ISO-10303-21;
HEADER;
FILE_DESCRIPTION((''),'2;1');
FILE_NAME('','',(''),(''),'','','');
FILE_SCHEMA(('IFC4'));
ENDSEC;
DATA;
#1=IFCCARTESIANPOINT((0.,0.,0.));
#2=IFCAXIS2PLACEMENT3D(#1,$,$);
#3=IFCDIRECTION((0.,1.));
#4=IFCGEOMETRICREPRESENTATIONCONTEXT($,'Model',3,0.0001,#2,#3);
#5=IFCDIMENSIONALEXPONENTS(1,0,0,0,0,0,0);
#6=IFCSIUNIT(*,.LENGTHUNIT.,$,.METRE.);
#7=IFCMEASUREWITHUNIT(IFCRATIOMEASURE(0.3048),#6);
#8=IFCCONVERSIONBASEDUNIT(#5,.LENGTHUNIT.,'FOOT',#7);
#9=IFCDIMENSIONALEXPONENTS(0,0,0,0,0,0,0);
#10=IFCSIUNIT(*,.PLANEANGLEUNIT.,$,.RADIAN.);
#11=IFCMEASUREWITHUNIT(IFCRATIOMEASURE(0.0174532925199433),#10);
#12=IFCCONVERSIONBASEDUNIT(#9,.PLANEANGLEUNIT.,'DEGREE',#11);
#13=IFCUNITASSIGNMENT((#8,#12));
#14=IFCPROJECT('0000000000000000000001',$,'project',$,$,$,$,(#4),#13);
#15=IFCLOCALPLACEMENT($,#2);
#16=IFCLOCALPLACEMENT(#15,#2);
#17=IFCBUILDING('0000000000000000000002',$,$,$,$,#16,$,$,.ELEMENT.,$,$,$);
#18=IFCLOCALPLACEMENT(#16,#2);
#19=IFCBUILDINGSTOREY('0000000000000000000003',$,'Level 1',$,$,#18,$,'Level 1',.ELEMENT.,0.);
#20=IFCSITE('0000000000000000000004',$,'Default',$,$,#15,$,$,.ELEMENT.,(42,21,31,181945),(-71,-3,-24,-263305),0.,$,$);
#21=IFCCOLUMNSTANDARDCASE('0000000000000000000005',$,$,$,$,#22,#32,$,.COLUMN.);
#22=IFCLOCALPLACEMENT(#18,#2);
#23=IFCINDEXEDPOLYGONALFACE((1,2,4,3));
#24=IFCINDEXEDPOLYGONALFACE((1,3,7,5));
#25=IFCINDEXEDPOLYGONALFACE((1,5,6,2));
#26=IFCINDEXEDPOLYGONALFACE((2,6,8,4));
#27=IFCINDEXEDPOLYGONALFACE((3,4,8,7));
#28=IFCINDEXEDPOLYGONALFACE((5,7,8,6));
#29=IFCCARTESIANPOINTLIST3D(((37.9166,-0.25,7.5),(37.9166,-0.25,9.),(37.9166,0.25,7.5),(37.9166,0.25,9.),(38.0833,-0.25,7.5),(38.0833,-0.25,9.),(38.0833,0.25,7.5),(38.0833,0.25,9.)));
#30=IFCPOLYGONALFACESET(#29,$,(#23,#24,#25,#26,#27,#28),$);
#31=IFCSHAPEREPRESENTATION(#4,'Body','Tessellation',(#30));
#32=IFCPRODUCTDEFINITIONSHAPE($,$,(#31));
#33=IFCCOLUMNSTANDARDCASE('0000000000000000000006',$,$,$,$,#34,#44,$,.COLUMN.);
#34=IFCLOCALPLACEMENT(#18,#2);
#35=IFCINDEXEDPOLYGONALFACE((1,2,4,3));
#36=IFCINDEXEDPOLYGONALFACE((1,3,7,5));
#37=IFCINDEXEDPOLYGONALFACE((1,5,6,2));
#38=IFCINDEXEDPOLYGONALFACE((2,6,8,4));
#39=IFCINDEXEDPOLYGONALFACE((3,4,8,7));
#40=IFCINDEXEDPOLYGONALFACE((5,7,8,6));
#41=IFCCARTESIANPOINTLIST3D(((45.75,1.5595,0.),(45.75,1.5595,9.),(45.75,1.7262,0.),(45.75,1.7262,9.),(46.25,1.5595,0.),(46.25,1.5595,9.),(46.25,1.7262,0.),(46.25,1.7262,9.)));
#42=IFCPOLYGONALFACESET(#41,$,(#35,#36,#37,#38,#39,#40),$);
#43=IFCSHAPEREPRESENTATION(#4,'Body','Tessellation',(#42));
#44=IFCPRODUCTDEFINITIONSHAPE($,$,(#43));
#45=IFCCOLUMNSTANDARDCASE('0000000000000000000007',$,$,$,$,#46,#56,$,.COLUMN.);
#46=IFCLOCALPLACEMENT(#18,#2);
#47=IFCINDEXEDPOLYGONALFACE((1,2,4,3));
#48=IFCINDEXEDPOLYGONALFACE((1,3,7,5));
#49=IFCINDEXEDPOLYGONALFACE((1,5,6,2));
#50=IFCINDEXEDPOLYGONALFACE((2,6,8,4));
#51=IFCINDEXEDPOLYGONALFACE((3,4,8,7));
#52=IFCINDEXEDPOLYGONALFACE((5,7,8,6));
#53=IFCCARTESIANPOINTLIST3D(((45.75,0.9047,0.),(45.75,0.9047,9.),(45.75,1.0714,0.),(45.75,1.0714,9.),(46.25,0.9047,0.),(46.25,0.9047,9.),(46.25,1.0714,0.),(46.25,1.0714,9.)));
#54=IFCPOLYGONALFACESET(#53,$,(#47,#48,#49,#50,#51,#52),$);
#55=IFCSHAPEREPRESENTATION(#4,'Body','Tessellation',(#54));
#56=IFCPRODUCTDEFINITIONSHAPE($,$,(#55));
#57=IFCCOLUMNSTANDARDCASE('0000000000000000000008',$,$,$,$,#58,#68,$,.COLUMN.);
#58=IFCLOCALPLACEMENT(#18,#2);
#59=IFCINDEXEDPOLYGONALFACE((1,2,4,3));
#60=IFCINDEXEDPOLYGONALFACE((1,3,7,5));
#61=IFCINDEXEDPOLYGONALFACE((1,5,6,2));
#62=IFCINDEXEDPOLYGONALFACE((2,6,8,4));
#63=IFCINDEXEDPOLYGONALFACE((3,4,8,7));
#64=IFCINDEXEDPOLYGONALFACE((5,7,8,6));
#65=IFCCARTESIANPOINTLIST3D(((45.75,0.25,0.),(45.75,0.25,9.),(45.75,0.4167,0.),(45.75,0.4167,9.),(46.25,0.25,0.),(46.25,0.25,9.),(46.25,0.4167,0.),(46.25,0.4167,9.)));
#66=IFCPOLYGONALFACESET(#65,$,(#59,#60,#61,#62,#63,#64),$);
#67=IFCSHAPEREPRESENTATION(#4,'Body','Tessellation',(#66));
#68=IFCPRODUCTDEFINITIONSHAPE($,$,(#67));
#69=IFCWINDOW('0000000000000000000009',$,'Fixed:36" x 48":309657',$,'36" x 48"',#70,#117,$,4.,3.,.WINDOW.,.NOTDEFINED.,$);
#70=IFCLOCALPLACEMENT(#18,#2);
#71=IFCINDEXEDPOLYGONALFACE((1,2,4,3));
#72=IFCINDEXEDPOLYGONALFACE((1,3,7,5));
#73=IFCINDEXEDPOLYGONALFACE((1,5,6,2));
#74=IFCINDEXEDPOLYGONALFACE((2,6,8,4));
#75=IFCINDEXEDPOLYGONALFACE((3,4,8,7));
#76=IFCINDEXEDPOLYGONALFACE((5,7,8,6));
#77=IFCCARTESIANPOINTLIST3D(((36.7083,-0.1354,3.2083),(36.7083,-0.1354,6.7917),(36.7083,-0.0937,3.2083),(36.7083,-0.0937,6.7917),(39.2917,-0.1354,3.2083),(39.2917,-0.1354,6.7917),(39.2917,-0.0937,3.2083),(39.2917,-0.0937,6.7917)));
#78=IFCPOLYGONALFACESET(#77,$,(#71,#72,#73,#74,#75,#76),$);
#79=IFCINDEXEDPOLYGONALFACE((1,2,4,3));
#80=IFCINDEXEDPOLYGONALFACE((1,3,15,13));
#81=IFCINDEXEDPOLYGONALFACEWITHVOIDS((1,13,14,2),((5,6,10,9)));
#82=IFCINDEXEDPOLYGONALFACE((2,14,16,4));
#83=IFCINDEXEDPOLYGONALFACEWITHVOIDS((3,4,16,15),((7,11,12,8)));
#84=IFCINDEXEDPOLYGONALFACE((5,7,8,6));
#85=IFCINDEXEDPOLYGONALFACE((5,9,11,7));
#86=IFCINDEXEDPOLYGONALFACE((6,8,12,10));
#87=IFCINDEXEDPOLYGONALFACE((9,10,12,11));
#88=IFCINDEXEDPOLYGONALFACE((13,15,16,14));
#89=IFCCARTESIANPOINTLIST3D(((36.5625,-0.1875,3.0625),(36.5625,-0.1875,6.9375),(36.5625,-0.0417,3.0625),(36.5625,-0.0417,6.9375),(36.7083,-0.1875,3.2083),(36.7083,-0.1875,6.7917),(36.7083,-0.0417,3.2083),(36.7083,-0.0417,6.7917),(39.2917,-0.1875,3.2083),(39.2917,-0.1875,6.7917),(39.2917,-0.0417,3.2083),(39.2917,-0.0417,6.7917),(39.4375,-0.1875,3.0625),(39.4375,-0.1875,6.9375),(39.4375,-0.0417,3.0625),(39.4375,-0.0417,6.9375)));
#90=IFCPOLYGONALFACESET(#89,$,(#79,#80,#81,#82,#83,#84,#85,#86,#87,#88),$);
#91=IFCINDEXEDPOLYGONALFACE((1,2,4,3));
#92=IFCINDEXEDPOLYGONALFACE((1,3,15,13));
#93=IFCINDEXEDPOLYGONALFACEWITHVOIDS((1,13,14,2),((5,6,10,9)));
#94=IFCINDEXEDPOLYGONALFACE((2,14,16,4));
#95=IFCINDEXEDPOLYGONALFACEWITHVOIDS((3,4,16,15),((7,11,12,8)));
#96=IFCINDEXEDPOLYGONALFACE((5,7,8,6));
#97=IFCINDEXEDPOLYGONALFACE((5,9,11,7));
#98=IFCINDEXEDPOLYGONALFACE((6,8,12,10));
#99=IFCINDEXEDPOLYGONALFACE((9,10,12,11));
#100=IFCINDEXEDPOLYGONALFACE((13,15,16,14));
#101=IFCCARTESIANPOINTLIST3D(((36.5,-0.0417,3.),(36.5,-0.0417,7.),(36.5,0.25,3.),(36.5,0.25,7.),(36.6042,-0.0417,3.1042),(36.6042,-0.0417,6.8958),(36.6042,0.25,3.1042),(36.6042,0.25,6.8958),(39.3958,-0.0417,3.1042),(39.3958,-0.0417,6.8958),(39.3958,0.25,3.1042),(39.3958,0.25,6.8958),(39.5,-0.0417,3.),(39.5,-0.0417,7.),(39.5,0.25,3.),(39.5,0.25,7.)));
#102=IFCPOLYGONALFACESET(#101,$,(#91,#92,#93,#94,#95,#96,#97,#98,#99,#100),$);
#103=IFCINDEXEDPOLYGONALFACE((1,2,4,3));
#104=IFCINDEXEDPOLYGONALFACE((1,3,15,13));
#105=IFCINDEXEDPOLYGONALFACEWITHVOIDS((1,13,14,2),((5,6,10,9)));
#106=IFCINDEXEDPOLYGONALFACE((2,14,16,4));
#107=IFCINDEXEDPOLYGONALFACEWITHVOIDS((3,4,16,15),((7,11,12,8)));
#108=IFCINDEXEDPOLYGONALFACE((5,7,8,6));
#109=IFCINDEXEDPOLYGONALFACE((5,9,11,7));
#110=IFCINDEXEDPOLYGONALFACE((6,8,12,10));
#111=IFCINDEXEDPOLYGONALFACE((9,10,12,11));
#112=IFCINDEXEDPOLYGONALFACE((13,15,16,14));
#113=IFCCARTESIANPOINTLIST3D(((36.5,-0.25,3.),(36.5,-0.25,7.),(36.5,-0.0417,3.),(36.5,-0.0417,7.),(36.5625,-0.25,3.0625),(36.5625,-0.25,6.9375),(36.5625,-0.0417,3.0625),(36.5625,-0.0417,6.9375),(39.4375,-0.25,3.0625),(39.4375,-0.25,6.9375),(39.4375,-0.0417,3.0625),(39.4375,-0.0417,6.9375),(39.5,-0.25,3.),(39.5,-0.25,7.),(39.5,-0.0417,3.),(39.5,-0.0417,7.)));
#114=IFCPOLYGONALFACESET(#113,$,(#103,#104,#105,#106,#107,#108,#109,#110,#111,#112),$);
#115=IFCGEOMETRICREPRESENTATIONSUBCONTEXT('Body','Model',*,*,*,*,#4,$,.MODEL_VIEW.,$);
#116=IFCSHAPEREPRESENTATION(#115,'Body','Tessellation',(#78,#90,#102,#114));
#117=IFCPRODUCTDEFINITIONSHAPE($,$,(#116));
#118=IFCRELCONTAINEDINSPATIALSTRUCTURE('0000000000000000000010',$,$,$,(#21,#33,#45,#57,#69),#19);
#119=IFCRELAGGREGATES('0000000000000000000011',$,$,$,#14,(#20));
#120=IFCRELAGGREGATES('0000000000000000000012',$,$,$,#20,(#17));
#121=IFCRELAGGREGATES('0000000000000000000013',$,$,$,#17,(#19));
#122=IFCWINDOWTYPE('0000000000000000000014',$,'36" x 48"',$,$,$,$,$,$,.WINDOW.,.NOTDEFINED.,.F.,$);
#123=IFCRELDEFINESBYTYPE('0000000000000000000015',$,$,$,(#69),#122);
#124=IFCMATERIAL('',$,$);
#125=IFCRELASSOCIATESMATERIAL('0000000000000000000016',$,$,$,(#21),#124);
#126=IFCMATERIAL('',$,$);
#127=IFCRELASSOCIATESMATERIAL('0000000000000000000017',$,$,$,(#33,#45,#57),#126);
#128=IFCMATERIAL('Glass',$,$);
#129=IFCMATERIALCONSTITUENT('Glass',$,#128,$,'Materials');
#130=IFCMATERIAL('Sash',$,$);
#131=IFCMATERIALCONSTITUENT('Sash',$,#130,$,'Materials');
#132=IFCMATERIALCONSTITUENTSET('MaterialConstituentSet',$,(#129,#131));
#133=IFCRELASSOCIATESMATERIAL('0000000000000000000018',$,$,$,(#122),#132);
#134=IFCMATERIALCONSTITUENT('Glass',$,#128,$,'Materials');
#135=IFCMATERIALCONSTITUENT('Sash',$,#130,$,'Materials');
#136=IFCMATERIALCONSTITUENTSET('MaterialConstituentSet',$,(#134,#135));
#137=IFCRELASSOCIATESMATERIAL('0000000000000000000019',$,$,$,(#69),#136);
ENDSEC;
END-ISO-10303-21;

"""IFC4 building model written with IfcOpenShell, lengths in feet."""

from ifc_helpers import new_model, entity, si_unit, converted_unit, direction, frame, frame_2d, origin, place, context, subcontext, project, spatial, polyline, rectangle, outline, extrude, source, transform, mapped, material, constituent, constituent_set, type_object, type_shapes, element, save


model = new_model("IFC4")

# Units and contexts
model_context = context("Model", 3, precision=0.0001, world=origin(), true_north=direction((0.0, 1.0)))
body_context = subcontext(model_context, "Body", "Model", "MODEL_VIEW")
ifc_project = project(units=[converted_unit("LENGTHUNIT", "FOOT", entity("IfcRatioMeasure", 0.3048), si_unit("LENGTHUNIT", "METRE"), dimensions=[1, 0, 0, 0, 0, 0, 0]), converted_unit("PLANEANGLEUNIT", "DEGREE", entity("IfcRatioMeasure", 0.0174532925199433), si_unit("PLANEANGLEUNIT", "RADIAN"), dimensions=[0, 0, 0, 0, 0, 0, 0])], contexts=[model_context])

# Site, building, storey
site_placement = place(None, origin())
site = spatial("IfcSite", under=ifc_project, at=site_placement, Name="Default", CompositionType="ELEMENT", RefLatitude=(42, 21, 31, 181945), RefLongitude=(-71, -3, -24, -263305), RefElevation=0.0)
building_placement = place(site_placement, origin())
building = spatial("IfcBuilding", under=site, at=building_placement, CompositionType="ELEMENT")
storey_placement = place(building_placement, origin())
storey = spatial("IfcBuildingStorey", under=building, at=storey_placement, Name="Level 1", LongName="Level 1", CompositionType="ELEMENT", Elevation=0.0)

# Columns
placement_1 = place(storey_placement, frame((46.25, 0.0, 0.0), z_axis=(0.0, 0.0, 1.0), x_axis=(-1.0, 0.0, 0.0)))
ifc_material_1 = material(Name="")
for number, where, z_axis, x_axis in (
    (1, (8.25, 0.0, 7.5), (0.0, 0.0, 1.0), (1.0, 0.0, 0.0)),
):
    element("IfcColumnStandardCase", number, at=place(placement_1, frame(where, z_axis=z_axis, x_axis=x_axis)), inside=storey, material=ifc_material_1, PredefinedType="COLUMN", context=model_context, shape_type="SweptSolid", body=[
        extrude(rectangle(XDim=0.1667, YDim=0.5), origin(), (0.0, 0.0, 1.0), 1.5),
    ])
ifc_material_2 = material(Name="")
placement_2 = place(storey_placement, frame((46.0, 46.25, 0.0), z_axis=(0.0, 0.0, 1.0), x_axis=(0.0, -1.0, 0.0)))
for number, where, z_axis, x_axis in (
    (2, (44.6072, 0.0, 0.0), (0.0, 0.0, 1.0), (1.0, 0.0, 0.0)),
    (3, (45.262, 0.0, 0.0), (0.0, 0.0, 1.0), (1.0, 0.0, 0.0)),
    (4, (45.9167, 0.0, 0.0), (0.0, 0.0, 1.0), (1.0, 0.0, 0.0)),
):
    element("IfcColumnStandardCase", number, at=place(placement_2, frame(where, z_axis=z_axis, x_axis=x_axis)), inside=storey, material=ifc_material_2, PredefinedType="COLUMN", context=model_context, shape_type="SweptSolid", body=[
        extrude(rectangle(XDim=0.1667, YDim=0.5), origin(), (0.0, 0.0, 1.0), 9.0),
    ])

# Window
ifc_material_3 = material(Name="Glass")
ifc_constituent_1 = constituent(ifc_material_3, Name="Glass", Category="Materials")
ifc_material_4 = material(Name="Sash")
ifc_constituent_2 = constituent(ifc_material_4, Name="Sash", Category="Materials")
ifc_constituent_set_1 = constituent_set(constituents=[ifc_constituent_1, ifc_constituent_2], Name="MaterialConstituentSet")
ifc_constituent_3 = constituent(ifc_material_3, Name="Glass", Category="Materials")
ifc_constituent_4 = constituent(ifc_material_4, Name="Sash", Category="Materials")
ifc_constituent_set_2 = constituent_set(constituents=[ifc_constituent_3, ifc_constituent_4], Name="MaterialConstituentSet")
window_type = type_object("IfcWindowType", Name="36\" x 48\"", ParameterTakesPrecedence=False, PartitioningType="NOTDEFINED", PredefinedType="WINDOW", material=ifc_constituent_set_2)
shared_shape = source(origin(), body_context, "Body", "SweptSolid", [
    extrude(rectangle(XDim=0.0417, YDim=2.5833, at=frame_2d((0.0, 0.0), x_axis=(1.0, 0.0))), frame((1.5, 0.3646, 0.2083), z_axis=(0.0, 0.0, 1.0), x_axis=(0.0, 1.0, 0.0)), (0.0, 0.0, 1.0), 3.5833),
    extrude(outline(polyline([(-1.4375, -1.9375), (1.4375, -1.9375), (1.4375, 1.9375), (-1.4375, 1.9375), (-1.4375, -1.9375)]), holes=[polyline([(-1.2917, -1.7917), (-1.2917, 1.7917), (1.2917, 1.7917), (1.2917, -1.7917), (-1.2917, -1.7917)])]), frame((1.5, 0.2917, 2.0), z_axis=(0.0, 1.0, 0.0), x_axis=(1.0, 0.0, 0.0)), (0.0, 0.0, 1.0), 0.1458),
    extrude(outline(polyline([(-1.5, -2.0), (1.5, -2.0), (1.5, 2.0), (-1.5, 2.0), (-1.5, -2.0)]), holes=[polyline([(-1.3958, -1.8958), (-1.3958, 1.8958), (1.3958, 1.8958), (1.3958, -1.8958), (-1.3958, -1.8958)])]), frame((1.5, 0.0, 2.0), z_axis=(0.0, 1.0, 0.0), x_axis=(1.0, 0.0, 0.0)), (0.0, 0.0, 1.0), 0.2917),
    extrude(outline(polyline([(-2.0, -1.5), (2.0, -1.5), (2.0, 1.5), (-2.0, 1.5), (-2.0, -1.5)]), holes=[polyline([(-1.9375, -1.4375), (-1.9375, 1.4375), (1.9375, 1.4375), (1.9375, -1.4375), (-1.9375, -1.4375)])]), frame((1.5, 0.2917, 2.0), z_axis=(0.0, 1.0, 0.0), x_axis=(0.0, 0.0, -1.0)), (0.0, 0.0, 1.0), 0.2083),
])
type_shapes(window_type, [shared_shape])
placement_3 = place(placement_1, frame((6.75, -0.25, 3.0)))
window_placement = place(placement_3, origin())
element("IfcWindow", 5, at=window_placement, inside=storey, type_object=window_type, material=ifc_constituent_set_1, Name="Fixed:36\" x 48\":309657", ObjectType="36\" x 48\"", OverallHeight=4.0, OverallWidth=3.0, PartitioningType="NOTDEFINED", PredefinedType="WINDOW", context=body_context, shape_type="MappedRepresentation", body=[
    mapped(shared_shape, transform((0.0, 0.0, 0.0), scale=1.0)),
])

save(model, "model.ifc")
